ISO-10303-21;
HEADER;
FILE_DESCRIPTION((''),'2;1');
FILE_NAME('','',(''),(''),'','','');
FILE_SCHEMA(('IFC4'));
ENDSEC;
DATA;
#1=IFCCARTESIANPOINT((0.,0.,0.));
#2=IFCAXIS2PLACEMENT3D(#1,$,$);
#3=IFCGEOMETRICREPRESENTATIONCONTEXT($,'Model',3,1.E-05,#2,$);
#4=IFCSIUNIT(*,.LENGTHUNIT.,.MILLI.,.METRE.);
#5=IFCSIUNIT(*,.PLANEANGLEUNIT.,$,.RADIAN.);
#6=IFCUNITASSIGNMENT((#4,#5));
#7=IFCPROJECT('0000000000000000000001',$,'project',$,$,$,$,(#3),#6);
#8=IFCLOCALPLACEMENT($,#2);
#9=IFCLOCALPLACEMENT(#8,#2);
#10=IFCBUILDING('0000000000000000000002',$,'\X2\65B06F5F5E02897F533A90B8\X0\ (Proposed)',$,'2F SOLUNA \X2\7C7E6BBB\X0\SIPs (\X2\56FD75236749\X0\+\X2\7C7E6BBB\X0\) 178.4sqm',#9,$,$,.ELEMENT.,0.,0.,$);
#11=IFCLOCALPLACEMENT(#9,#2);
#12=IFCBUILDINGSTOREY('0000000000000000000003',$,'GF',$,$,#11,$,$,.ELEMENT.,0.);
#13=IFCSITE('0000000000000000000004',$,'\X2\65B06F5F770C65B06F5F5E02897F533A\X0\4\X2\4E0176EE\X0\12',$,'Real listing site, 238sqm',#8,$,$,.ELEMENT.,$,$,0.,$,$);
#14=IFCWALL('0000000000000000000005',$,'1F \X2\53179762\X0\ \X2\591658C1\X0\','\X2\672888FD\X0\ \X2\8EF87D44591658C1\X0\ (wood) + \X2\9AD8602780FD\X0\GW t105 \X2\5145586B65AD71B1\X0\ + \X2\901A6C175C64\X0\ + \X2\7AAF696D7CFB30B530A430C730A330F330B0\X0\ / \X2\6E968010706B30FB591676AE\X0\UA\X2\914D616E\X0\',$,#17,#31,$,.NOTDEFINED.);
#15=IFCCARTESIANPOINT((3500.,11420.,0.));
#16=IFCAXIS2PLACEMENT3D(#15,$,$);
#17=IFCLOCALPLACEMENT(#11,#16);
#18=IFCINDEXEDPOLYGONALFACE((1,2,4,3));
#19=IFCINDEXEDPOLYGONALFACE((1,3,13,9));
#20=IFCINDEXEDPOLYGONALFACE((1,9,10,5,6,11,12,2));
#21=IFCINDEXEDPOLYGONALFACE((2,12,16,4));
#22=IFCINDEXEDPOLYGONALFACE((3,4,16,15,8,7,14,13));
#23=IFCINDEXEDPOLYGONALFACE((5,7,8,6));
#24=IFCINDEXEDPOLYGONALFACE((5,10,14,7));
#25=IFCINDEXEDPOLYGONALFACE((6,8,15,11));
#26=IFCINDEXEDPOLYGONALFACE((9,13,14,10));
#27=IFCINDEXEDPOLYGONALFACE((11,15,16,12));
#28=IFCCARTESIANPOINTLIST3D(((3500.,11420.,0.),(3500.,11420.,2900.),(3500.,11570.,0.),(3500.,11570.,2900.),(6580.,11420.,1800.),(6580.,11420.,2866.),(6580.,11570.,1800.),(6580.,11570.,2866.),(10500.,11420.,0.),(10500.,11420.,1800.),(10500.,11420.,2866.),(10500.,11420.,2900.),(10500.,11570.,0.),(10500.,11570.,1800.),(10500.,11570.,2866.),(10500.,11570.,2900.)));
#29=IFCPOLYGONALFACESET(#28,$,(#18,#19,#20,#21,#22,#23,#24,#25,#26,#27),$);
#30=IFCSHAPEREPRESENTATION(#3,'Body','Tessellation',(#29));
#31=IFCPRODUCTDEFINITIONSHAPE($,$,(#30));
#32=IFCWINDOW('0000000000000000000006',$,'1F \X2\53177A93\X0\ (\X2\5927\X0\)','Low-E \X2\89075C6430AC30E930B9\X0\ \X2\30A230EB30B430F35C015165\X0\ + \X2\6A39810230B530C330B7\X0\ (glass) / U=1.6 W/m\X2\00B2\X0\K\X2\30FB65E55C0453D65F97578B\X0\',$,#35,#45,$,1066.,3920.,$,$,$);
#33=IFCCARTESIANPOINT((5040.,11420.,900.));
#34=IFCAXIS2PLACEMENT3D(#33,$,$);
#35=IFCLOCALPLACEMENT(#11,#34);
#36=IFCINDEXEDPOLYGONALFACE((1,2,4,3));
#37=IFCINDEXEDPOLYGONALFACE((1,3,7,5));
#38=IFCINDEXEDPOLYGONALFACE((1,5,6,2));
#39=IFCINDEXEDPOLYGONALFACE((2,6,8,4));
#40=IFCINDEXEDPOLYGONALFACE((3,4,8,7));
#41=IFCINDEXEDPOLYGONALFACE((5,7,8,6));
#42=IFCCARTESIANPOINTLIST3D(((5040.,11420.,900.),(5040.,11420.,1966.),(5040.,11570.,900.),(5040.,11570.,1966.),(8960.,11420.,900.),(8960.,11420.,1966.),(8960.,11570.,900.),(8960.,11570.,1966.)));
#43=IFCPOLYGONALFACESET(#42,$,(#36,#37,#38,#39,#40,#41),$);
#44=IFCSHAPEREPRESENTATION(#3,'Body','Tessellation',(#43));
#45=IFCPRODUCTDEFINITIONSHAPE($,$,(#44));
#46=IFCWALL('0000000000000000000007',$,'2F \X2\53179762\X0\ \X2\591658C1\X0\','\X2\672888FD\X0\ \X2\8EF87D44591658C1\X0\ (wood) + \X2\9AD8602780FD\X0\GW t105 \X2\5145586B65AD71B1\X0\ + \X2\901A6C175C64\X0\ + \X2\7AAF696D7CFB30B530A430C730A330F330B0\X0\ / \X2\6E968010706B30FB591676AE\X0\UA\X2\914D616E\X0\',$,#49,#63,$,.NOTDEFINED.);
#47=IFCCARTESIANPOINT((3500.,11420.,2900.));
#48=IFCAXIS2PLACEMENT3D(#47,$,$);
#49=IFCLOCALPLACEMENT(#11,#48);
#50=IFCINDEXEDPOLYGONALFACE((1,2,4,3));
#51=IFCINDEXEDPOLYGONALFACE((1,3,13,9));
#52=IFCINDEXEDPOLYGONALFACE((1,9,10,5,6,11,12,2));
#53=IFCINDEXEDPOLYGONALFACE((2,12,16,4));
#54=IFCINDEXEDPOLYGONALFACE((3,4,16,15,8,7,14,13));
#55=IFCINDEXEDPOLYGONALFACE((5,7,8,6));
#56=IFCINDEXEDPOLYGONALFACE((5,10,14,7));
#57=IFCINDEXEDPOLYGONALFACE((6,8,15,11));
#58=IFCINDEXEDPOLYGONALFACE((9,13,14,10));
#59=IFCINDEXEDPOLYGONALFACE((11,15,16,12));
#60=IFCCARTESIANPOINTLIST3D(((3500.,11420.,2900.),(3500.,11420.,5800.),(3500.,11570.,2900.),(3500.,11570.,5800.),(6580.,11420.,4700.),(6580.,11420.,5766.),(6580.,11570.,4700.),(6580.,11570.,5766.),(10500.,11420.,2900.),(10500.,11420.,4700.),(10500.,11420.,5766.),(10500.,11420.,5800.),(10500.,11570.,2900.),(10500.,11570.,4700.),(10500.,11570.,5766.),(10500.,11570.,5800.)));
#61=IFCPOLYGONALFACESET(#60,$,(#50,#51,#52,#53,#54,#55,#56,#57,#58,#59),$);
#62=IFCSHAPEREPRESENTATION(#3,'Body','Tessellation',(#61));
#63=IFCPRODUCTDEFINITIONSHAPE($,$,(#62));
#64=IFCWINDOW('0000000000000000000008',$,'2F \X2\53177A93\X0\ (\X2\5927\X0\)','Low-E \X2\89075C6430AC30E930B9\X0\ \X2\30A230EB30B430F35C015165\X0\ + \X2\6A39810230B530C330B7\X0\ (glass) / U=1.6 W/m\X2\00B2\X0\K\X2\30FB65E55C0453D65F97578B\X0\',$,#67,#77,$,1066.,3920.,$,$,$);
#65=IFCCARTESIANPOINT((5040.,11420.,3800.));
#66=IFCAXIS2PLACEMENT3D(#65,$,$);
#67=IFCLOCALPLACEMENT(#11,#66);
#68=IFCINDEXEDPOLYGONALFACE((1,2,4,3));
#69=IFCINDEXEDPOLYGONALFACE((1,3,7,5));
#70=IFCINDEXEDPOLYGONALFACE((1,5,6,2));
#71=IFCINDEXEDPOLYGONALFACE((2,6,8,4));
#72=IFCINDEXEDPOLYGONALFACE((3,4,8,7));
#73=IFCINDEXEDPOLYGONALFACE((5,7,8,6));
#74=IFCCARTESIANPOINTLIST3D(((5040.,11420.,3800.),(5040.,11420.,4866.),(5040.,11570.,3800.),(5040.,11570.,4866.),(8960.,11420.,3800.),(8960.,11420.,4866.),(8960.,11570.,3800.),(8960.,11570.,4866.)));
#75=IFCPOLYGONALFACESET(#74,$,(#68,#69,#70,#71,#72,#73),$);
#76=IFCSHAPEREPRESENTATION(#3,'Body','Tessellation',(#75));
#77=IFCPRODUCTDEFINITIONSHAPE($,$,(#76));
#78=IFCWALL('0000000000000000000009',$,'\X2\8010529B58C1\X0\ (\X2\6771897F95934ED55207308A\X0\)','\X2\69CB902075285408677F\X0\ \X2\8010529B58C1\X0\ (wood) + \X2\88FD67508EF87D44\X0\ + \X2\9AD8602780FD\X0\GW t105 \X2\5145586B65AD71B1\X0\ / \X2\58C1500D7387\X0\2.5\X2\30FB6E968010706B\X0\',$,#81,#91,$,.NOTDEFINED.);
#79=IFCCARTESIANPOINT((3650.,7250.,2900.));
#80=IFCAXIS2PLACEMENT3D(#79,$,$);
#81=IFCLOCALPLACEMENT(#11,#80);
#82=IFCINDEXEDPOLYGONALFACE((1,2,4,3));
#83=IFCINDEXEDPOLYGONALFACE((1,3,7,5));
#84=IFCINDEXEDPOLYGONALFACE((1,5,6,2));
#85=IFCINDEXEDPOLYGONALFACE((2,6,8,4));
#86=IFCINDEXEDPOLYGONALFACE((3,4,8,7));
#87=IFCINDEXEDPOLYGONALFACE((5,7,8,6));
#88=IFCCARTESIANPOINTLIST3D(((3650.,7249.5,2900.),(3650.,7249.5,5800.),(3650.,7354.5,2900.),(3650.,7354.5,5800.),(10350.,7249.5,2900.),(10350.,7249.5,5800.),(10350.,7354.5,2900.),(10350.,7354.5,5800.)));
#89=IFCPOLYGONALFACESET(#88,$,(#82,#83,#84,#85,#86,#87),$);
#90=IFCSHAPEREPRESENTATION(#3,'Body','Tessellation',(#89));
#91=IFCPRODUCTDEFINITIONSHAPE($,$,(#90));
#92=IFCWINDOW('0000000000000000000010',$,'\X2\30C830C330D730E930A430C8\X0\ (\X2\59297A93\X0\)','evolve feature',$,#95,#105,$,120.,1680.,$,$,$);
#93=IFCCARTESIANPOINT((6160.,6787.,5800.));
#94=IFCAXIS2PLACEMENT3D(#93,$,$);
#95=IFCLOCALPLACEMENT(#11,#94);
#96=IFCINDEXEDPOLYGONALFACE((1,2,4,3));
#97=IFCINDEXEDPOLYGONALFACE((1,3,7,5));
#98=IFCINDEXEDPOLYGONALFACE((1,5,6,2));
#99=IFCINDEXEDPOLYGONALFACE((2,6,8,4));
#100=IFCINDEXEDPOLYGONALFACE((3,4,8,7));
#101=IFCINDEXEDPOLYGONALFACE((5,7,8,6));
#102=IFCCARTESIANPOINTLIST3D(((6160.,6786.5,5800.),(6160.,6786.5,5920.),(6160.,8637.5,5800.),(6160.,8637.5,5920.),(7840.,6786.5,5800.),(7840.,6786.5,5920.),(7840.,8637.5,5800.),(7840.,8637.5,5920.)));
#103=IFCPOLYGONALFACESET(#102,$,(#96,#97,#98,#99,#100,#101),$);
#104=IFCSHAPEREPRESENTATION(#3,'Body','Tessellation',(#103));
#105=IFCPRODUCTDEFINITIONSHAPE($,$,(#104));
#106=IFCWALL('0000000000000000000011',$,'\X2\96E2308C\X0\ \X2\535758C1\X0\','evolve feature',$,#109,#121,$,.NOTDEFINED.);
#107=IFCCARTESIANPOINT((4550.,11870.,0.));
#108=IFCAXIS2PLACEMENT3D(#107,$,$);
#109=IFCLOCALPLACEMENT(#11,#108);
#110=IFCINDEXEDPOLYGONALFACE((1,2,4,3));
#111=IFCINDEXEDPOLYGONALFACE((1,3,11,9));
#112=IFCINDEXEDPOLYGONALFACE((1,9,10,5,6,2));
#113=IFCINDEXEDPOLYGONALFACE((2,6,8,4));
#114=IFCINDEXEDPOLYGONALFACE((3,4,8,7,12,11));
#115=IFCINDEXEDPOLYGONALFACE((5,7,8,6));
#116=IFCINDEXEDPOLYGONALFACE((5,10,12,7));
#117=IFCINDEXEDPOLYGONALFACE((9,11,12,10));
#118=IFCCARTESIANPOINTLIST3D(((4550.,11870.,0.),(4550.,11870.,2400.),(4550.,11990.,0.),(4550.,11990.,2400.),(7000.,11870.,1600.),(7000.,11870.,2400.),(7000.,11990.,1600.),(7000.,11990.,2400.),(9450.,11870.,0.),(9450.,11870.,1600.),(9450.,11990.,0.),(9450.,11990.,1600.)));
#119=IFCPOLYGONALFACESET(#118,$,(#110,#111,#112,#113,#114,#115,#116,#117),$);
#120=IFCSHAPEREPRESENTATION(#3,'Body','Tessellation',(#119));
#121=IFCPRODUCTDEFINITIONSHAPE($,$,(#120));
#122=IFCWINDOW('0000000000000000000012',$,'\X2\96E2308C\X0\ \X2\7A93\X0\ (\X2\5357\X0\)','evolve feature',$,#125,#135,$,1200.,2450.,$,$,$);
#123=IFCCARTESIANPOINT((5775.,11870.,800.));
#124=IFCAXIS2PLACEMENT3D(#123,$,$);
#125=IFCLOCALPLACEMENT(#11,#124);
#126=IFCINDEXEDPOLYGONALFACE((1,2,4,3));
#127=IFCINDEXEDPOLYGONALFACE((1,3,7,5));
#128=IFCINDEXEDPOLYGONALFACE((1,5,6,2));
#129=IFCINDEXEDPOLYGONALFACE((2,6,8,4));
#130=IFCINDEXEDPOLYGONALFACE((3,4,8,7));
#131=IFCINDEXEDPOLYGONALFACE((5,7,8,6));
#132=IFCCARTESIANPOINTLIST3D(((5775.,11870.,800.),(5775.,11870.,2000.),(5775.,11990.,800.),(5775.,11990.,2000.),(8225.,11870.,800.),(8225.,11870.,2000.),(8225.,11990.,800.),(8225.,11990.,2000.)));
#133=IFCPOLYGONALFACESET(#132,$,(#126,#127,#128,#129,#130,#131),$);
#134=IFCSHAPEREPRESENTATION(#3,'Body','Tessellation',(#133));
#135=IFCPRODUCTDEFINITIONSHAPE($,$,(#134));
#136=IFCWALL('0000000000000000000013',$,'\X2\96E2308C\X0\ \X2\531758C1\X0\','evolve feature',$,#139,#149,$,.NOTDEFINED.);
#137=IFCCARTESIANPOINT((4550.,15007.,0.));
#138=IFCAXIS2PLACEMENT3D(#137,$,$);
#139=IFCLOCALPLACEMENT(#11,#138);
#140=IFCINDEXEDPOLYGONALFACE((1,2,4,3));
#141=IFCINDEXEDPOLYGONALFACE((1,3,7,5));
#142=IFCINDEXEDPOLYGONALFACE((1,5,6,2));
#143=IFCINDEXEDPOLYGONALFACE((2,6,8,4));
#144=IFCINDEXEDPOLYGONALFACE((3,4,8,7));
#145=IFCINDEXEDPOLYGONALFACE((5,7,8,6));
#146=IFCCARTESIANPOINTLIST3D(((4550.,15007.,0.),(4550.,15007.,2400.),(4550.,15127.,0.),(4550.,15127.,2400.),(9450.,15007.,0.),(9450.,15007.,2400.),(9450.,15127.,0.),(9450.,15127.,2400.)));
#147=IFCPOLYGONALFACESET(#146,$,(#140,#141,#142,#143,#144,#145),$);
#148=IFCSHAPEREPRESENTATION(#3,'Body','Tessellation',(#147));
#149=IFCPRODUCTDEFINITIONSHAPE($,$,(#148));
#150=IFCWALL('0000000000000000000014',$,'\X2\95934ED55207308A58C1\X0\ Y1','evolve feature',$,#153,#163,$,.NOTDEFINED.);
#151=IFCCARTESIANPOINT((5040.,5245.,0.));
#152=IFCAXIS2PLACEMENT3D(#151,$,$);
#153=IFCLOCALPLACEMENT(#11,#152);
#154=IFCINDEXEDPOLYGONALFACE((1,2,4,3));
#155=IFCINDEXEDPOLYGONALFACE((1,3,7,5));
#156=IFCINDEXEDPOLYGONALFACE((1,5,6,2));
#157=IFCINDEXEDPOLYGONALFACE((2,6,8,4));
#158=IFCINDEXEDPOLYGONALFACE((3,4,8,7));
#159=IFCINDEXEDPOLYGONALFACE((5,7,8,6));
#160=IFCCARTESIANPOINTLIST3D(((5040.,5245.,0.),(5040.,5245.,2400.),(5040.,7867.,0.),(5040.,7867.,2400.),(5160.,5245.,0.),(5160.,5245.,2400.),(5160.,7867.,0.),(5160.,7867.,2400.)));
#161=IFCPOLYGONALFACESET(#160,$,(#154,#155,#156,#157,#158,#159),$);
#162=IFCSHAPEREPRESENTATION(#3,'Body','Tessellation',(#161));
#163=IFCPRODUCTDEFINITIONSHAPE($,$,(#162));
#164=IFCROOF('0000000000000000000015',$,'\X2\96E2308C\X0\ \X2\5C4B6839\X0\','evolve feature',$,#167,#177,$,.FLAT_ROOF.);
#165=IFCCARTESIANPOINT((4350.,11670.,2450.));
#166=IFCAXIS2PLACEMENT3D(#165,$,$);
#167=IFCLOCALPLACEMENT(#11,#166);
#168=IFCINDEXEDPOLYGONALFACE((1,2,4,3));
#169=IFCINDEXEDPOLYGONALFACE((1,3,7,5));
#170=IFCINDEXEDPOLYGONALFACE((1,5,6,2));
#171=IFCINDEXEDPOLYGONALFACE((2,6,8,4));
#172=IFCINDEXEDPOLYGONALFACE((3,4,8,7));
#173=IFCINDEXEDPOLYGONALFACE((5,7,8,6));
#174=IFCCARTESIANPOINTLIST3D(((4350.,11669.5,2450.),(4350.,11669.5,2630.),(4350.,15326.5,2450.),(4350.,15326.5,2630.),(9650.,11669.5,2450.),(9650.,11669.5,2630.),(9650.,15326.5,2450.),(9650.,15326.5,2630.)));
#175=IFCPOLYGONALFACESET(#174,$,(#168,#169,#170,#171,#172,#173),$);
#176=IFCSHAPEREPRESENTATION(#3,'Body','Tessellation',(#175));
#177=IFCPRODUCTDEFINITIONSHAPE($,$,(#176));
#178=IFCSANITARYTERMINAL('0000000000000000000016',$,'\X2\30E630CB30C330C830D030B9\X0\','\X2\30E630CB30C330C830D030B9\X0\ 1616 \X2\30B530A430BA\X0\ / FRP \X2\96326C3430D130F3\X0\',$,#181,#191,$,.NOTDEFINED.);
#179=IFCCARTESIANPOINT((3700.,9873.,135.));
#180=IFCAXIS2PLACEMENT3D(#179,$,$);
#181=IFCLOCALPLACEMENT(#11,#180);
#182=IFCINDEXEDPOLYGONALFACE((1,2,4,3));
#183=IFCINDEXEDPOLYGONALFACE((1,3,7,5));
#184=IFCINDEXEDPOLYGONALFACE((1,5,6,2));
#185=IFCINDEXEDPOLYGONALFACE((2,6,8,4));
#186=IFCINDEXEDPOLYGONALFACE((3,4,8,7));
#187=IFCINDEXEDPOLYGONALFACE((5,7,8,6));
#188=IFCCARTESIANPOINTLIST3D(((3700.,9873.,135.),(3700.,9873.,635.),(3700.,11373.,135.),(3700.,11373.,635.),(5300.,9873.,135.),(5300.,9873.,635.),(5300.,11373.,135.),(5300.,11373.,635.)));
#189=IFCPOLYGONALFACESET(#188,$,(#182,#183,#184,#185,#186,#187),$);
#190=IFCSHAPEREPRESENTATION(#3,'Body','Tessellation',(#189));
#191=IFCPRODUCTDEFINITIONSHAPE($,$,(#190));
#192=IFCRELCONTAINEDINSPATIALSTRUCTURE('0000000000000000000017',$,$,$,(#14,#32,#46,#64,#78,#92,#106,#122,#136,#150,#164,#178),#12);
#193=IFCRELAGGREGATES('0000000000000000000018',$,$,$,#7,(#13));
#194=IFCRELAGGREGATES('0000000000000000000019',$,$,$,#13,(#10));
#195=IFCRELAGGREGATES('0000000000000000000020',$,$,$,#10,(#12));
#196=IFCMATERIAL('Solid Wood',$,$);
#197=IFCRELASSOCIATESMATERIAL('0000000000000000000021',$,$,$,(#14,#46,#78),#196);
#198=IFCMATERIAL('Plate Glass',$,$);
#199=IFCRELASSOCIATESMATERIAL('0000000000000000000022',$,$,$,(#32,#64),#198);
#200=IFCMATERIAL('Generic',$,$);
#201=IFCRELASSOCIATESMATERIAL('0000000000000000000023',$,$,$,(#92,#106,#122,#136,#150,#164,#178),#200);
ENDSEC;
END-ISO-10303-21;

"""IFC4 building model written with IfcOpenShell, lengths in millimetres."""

from ifc_helpers import new_model, si_unit, frame, frame_2d, origin, place, context, project, spatial, rectangle, extrude, material, element, fill, save


model = new_model("IFC4")

# Units and contexts
model_context = context("Model", 3, precision=1e-05, world=origin())
ifc_project = project(units=[si_unit("LENGTHUNIT", "METRE", prefix="MILLI"), si_unit("PLANEANGLEUNIT", "RADIAN")], contexts=[model_context])

# Site, building, storey
site_placement = place(None, origin())
site = spatial("IfcSite", under=ifc_project, at=site_placement, Name="新潟県新潟市西区4丁目12", ObjectType="Real listing site, 238sqm", CompositionType="ELEMENT", RefElevation=0.0)
building_placement = place(site_placement, origin())
building = spatial("IfcBuilding", under=site, at=building_placement, Name="新潟市西区邸 (Proposed)", ObjectType="2F SOLUNA 籾殻SIPs (国産杉+籾殻) 178.4sqm", CompositionType="ELEMENT", ElevationOfRefHeight=0.0, ElevationOfTerrain=0.0)
storey_placement = place(building_placement, origin())
storey = spatial("IfcBuildingStorey", under=building, at=storey_placement, Name="GF", CompositionType="ELEMENT", Elevation=0.0)

# Shared definitions
ifc_material_1 = material(Name="Generic")

# Wall, opening, window
ifc_material_2 = material(Name="Solid Wood")
wall_1_placement = place(storey_placement, frame((3500.0, 11420.0, 0.0)))
wall_1 = element("IfcWall", 1, at=wall_1_placement, inside=storey, material=ifc_material_2, Name="1F 北面 外壁", Description="木製 軸組外壁 (wood) + 高性能GW t105 充填断熱 + 通気層 + 窯業系サイディング / 準耐火・外皮UA配慮", PredefinedType="NOTDEFINED", context=model_context, shape_type="SweptSolid", body=[
    extrude(rectangle(XDim=7000.0, YDim=150.0, at=frame_2d((3500.0, 75.0))), frame((3500.0, 11420.0, 0.0)), (0.0, 0.0, 1.0), 2900.0),
])
opening_1_placement = place(storey_placement, frame((5040.0, 11420.0, 900.0)))
opening_1 = element("IfcOpeningElement", 2, at=opening_1_placement, cuts=wall_1, PredefinedType="NOTDEFINED", context=model_context, shape_type="SweptSolid", body=[
    extrude(rectangle(XDim=3920.0, YDim=150.0, at=frame_2d((1960.0, 75.0))), frame((5040.0, 11420.0, 900.0)), (0.0, 0.0, 1.0), 1066.0),
])
ifc_material_3 = material(Name="Plate Glass")
window_1_placement = place(storey_placement, frame((5040.0, 11420.0, 900.0)))
window_1 = element("IfcWindow", 3, at=window_1_placement, inside=storey, material=ifc_material_3, Name="1F 北窓 (大)", Description="Low-E 複層ガラス アルゴン封入 + 樹脂サッシ (glass) / U=1.6 W/m²K・日射取得型", OverallHeight=1066.0, OverallWidth=3920.0, context=model_context, shape_type="SweptSolid", body=[
    extrude(rectangle(XDim=3920.0, YDim=150.0, at=frame_2d((1960.0, 75.0))), frame((5040.0, 11420.0, 900.0)), (0.0, 0.0, 1.0), 1066.0),
])
fill(opening_1, window_1)

# Wall, opening, window
wall_2_placement = place(storey_placement, frame((3500.0, 11420.0, 2900.0)))
wall_2 = element("IfcWall", 4, at=wall_2_placement, inside=storey, material=ifc_material_2, Name="2F 北面 外壁", Description="木製 軸組外壁 (wood) + 高性能GW t105 充填断熱 + 通気層 + 窯業系サイディング / 準耐火・外皮UA配慮", PredefinedType="NOTDEFINED", context=model_context, shape_type="SweptSolid", body=[
    extrude(rectangle(XDim=7000.0, YDim=150.0, at=frame_2d((3500.0, 75.0))), frame((3500.0, 11420.0, 2900.0)), (0.0, 0.0, 1.0), 2900.0),
])
opening_2_placement = place(storey_placement, frame((5040.0, 11420.0, 3800.0)))
opening_2 = element("IfcOpeningElement", 5, at=opening_2_placement, cuts=wall_2, PredefinedType="NOTDEFINED", context=model_context, shape_type="SweptSolid", body=[
    extrude(rectangle(XDim=3920.0, YDim=150.0, at=frame_2d((1960.0, 75.0))), frame((5040.0, 11420.0, 3800.0)), (0.0, 0.0, 1.0), 1066.0),
])
window_2_placement = place(storey_placement, frame((5040.0, 11420.0, 3800.0)))
window_2 = element("IfcWindow", 6, at=window_2_placement, inside=storey, material=ifc_material_3, Name="2F 北窓 (大)", Description="Low-E 複層ガラス アルゴン封入 + 樹脂サッシ (glass) / U=1.6 W/m²K・日射取得型", OverallHeight=1066.0, OverallWidth=3920.0, context=model_context, shape_type="SweptSolid", body=[
    extrude(rectangle(XDim=3920.0, YDim=150.0, at=frame_2d((1960.0, 75.0))), frame((5040.0, 11420.0, 3800.0)), (0.0, 0.0, 1.0), 1066.0),
])
fill(opening_2, window_2)

# Wall
wall_3_placement = place(storey_placement, frame((3650.0, 7250.0, 2900.0)))
element("IfcWall", 7, at=wall_3_placement, inside=storey, material=ifc_material_2, Name="耐力壁 (東西間仕切り)", Description="構造用合板 耐力壁 (wood) + 製材軸組 + 高性能GW t105 充填断熱 / 壁倍率2.5・準耐火", PredefinedType="NOTDEFINED", context=model_context, shape_type="SweptSolid", body=[
    extrude(rectangle(XDim=6700.0, YDim=105.0, at=frame_2d((3350.0, 52.0))), frame((3650.0, 7250.0, 2900.0)), (0.0, 0.0, 1.0), 2900.0),
])

# Window
window_3_placement = place(storey_placement, frame((6160.0, 6787.0, 5800.0)))
element("IfcWindow", 8, at=window_3_placement, inside=storey, material=ifc_material_1, Name="トップライト (天窓)", Description="evolve feature", OverallHeight=120.0, OverallWidth=1680.0, context=model_context, shape_type="SweptSolid", body=[
    extrude(rectangle(XDim=1680.0, YDim=1851.0, at=frame_2d((840.0, 925.0))), frame((6160.0, 6787.0, 5800.0)), (0.0, 0.0, 1.0), 120.0),
])

# Wall, opening, window
wall_4_placement = place(storey_placement, frame((4550.0, 11870.0, 0.0)))
wall_4 = element("IfcWall", 9, at=wall_4_placement, inside=storey, material=ifc_material_1, Name="離れ 南壁", Description="evolve feature", PredefinedType="NOTDEFINED", context=model_context, shape_type="SweptSolid", body=[
    extrude(rectangle(XDim=4900.0, YDim=120.0, at=frame_2d((2450.0, 60.0))), frame((4550.0, 11870.0, 0.0)), (0.0, 0.0, 1.0), 2400.0),
])
opening_3_placement = place(storey_placement, frame((5775.0, 11870.0, 800.0)))
opening_3 = element("IfcOpeningElement", 10, at=opening_3_placement, cuts=wall_4, PredefinedType="NOTDEFINED", context=model_context, shape_type="SweptSolid", body=[
    extrude(rectangle(XDim=2450.0, YDim=120.0, at=frame_2d((1225.0, 60.0))), frame((5775.0, 11870.0, 800.0)), (0.0, 0.0, 1.0), 1200.0),
])
window_4_placement = place(storey_placement, frame((5775.0, 11870.0, 800.0)))
window_4 = element("IfcWindow", 11, at=window_4_placement, inside=storey, material=ifc_material_1, Name="離れ 窓 (南)", Description="evolve feature", OverallHeight=1200.0, OverallWidth=2450.0, context=model_context, shape_type="SweptSolid", body=[
    extrude(rectangle(XDim=2450.0, YDim=120.0, at=frame_2d((1225.0, 60.0))), frame((5775.0, 11870.0, 800.0)), (0.0, 0.0, 1.0), 1200.0),
])
fill(opening_3, window_4)

# Walls
wall_5_placement = place(storey_placement, frame((4550.0, 15007.0, 0.0)))
element("IfcWall", 12, at=wall_5_placement, inside=storey, material=ifc_material_1, Name="離れ 北壁", Description="evolve feature", PredefinedType="NOTDEFINED", context=model_context, shape_type="SweptSolid", body=[
    extrude(rectangle(XDim=4900.0, YDim=120.0, at=frame_2d((2450.0, 60.0))), frame((4550.0, 15007.0, 0.0)), (0.0, 0.0, 1.0), 2400.0),
])
wall_6_placement = place(storey_placement, frame((5040.0, 5245.0, 0.0)))
element("IfcWall", 13, at=wall_6_placement, inside=storey, material=ifc_material_1, Name="間仕切り壁 Y1", Description="evolve feature", PredefinedType="NOTDEFINED", context=model_context, shape_type="SweptSolid", body=[
    extrude(rectangle(XDim=120.0, YDim=2622.0, at=frame_2d((60.0, 1311.0))), frame((5040.0, 5245.0, 0.0)), (0.0, 0.0, 1.0), 2400.0),
])

# Roof
roof_placement = place(storey_placement, frame((4350.0, 11670.0, 2450.0)))
element("IfcRoof", 14, at=roof_placement, inside=storey, material=ifc_material_1, Name="離れ 屋根", Description="evolve feature", PredefinedType="FLAT_ROOF", context=model_context, shape_type="SweptSolid", body=[
    extrude(rectangle(XDim=5300.0, YDim=3657.0, at=frame_2d((2650.0, 1828.0))), frame((4350.0, 11670.0, 2450.0)), (0.0, 0.0, 1.0), 180.0),
])

# Sanitary terminal
sanitary_terminal_1_placement = place(storey_placement, frame((3700.0, 9873.0, 135.0)))
element("IfcSanitaryTerminal", 15, at=sanitary_terminal_1_placement, inside=storey, material=ifc_material_1, Name="ユニットバス", Description="ユニットバス 1616 サイズ / FRP 防水パン", PredefinedType="NOTDEFINED", context=model_context, shape_type="SweptSolid", body=[
    extrude(rectangle(XDim=1600.0, YDim=1500.0, at=frame_2d((800.0, 750.0))), frame((3700.0, 9873.0, 135.0)), (0.0, 0.0, 1.0), 500.0),
])

save(model, "model.ifc")
